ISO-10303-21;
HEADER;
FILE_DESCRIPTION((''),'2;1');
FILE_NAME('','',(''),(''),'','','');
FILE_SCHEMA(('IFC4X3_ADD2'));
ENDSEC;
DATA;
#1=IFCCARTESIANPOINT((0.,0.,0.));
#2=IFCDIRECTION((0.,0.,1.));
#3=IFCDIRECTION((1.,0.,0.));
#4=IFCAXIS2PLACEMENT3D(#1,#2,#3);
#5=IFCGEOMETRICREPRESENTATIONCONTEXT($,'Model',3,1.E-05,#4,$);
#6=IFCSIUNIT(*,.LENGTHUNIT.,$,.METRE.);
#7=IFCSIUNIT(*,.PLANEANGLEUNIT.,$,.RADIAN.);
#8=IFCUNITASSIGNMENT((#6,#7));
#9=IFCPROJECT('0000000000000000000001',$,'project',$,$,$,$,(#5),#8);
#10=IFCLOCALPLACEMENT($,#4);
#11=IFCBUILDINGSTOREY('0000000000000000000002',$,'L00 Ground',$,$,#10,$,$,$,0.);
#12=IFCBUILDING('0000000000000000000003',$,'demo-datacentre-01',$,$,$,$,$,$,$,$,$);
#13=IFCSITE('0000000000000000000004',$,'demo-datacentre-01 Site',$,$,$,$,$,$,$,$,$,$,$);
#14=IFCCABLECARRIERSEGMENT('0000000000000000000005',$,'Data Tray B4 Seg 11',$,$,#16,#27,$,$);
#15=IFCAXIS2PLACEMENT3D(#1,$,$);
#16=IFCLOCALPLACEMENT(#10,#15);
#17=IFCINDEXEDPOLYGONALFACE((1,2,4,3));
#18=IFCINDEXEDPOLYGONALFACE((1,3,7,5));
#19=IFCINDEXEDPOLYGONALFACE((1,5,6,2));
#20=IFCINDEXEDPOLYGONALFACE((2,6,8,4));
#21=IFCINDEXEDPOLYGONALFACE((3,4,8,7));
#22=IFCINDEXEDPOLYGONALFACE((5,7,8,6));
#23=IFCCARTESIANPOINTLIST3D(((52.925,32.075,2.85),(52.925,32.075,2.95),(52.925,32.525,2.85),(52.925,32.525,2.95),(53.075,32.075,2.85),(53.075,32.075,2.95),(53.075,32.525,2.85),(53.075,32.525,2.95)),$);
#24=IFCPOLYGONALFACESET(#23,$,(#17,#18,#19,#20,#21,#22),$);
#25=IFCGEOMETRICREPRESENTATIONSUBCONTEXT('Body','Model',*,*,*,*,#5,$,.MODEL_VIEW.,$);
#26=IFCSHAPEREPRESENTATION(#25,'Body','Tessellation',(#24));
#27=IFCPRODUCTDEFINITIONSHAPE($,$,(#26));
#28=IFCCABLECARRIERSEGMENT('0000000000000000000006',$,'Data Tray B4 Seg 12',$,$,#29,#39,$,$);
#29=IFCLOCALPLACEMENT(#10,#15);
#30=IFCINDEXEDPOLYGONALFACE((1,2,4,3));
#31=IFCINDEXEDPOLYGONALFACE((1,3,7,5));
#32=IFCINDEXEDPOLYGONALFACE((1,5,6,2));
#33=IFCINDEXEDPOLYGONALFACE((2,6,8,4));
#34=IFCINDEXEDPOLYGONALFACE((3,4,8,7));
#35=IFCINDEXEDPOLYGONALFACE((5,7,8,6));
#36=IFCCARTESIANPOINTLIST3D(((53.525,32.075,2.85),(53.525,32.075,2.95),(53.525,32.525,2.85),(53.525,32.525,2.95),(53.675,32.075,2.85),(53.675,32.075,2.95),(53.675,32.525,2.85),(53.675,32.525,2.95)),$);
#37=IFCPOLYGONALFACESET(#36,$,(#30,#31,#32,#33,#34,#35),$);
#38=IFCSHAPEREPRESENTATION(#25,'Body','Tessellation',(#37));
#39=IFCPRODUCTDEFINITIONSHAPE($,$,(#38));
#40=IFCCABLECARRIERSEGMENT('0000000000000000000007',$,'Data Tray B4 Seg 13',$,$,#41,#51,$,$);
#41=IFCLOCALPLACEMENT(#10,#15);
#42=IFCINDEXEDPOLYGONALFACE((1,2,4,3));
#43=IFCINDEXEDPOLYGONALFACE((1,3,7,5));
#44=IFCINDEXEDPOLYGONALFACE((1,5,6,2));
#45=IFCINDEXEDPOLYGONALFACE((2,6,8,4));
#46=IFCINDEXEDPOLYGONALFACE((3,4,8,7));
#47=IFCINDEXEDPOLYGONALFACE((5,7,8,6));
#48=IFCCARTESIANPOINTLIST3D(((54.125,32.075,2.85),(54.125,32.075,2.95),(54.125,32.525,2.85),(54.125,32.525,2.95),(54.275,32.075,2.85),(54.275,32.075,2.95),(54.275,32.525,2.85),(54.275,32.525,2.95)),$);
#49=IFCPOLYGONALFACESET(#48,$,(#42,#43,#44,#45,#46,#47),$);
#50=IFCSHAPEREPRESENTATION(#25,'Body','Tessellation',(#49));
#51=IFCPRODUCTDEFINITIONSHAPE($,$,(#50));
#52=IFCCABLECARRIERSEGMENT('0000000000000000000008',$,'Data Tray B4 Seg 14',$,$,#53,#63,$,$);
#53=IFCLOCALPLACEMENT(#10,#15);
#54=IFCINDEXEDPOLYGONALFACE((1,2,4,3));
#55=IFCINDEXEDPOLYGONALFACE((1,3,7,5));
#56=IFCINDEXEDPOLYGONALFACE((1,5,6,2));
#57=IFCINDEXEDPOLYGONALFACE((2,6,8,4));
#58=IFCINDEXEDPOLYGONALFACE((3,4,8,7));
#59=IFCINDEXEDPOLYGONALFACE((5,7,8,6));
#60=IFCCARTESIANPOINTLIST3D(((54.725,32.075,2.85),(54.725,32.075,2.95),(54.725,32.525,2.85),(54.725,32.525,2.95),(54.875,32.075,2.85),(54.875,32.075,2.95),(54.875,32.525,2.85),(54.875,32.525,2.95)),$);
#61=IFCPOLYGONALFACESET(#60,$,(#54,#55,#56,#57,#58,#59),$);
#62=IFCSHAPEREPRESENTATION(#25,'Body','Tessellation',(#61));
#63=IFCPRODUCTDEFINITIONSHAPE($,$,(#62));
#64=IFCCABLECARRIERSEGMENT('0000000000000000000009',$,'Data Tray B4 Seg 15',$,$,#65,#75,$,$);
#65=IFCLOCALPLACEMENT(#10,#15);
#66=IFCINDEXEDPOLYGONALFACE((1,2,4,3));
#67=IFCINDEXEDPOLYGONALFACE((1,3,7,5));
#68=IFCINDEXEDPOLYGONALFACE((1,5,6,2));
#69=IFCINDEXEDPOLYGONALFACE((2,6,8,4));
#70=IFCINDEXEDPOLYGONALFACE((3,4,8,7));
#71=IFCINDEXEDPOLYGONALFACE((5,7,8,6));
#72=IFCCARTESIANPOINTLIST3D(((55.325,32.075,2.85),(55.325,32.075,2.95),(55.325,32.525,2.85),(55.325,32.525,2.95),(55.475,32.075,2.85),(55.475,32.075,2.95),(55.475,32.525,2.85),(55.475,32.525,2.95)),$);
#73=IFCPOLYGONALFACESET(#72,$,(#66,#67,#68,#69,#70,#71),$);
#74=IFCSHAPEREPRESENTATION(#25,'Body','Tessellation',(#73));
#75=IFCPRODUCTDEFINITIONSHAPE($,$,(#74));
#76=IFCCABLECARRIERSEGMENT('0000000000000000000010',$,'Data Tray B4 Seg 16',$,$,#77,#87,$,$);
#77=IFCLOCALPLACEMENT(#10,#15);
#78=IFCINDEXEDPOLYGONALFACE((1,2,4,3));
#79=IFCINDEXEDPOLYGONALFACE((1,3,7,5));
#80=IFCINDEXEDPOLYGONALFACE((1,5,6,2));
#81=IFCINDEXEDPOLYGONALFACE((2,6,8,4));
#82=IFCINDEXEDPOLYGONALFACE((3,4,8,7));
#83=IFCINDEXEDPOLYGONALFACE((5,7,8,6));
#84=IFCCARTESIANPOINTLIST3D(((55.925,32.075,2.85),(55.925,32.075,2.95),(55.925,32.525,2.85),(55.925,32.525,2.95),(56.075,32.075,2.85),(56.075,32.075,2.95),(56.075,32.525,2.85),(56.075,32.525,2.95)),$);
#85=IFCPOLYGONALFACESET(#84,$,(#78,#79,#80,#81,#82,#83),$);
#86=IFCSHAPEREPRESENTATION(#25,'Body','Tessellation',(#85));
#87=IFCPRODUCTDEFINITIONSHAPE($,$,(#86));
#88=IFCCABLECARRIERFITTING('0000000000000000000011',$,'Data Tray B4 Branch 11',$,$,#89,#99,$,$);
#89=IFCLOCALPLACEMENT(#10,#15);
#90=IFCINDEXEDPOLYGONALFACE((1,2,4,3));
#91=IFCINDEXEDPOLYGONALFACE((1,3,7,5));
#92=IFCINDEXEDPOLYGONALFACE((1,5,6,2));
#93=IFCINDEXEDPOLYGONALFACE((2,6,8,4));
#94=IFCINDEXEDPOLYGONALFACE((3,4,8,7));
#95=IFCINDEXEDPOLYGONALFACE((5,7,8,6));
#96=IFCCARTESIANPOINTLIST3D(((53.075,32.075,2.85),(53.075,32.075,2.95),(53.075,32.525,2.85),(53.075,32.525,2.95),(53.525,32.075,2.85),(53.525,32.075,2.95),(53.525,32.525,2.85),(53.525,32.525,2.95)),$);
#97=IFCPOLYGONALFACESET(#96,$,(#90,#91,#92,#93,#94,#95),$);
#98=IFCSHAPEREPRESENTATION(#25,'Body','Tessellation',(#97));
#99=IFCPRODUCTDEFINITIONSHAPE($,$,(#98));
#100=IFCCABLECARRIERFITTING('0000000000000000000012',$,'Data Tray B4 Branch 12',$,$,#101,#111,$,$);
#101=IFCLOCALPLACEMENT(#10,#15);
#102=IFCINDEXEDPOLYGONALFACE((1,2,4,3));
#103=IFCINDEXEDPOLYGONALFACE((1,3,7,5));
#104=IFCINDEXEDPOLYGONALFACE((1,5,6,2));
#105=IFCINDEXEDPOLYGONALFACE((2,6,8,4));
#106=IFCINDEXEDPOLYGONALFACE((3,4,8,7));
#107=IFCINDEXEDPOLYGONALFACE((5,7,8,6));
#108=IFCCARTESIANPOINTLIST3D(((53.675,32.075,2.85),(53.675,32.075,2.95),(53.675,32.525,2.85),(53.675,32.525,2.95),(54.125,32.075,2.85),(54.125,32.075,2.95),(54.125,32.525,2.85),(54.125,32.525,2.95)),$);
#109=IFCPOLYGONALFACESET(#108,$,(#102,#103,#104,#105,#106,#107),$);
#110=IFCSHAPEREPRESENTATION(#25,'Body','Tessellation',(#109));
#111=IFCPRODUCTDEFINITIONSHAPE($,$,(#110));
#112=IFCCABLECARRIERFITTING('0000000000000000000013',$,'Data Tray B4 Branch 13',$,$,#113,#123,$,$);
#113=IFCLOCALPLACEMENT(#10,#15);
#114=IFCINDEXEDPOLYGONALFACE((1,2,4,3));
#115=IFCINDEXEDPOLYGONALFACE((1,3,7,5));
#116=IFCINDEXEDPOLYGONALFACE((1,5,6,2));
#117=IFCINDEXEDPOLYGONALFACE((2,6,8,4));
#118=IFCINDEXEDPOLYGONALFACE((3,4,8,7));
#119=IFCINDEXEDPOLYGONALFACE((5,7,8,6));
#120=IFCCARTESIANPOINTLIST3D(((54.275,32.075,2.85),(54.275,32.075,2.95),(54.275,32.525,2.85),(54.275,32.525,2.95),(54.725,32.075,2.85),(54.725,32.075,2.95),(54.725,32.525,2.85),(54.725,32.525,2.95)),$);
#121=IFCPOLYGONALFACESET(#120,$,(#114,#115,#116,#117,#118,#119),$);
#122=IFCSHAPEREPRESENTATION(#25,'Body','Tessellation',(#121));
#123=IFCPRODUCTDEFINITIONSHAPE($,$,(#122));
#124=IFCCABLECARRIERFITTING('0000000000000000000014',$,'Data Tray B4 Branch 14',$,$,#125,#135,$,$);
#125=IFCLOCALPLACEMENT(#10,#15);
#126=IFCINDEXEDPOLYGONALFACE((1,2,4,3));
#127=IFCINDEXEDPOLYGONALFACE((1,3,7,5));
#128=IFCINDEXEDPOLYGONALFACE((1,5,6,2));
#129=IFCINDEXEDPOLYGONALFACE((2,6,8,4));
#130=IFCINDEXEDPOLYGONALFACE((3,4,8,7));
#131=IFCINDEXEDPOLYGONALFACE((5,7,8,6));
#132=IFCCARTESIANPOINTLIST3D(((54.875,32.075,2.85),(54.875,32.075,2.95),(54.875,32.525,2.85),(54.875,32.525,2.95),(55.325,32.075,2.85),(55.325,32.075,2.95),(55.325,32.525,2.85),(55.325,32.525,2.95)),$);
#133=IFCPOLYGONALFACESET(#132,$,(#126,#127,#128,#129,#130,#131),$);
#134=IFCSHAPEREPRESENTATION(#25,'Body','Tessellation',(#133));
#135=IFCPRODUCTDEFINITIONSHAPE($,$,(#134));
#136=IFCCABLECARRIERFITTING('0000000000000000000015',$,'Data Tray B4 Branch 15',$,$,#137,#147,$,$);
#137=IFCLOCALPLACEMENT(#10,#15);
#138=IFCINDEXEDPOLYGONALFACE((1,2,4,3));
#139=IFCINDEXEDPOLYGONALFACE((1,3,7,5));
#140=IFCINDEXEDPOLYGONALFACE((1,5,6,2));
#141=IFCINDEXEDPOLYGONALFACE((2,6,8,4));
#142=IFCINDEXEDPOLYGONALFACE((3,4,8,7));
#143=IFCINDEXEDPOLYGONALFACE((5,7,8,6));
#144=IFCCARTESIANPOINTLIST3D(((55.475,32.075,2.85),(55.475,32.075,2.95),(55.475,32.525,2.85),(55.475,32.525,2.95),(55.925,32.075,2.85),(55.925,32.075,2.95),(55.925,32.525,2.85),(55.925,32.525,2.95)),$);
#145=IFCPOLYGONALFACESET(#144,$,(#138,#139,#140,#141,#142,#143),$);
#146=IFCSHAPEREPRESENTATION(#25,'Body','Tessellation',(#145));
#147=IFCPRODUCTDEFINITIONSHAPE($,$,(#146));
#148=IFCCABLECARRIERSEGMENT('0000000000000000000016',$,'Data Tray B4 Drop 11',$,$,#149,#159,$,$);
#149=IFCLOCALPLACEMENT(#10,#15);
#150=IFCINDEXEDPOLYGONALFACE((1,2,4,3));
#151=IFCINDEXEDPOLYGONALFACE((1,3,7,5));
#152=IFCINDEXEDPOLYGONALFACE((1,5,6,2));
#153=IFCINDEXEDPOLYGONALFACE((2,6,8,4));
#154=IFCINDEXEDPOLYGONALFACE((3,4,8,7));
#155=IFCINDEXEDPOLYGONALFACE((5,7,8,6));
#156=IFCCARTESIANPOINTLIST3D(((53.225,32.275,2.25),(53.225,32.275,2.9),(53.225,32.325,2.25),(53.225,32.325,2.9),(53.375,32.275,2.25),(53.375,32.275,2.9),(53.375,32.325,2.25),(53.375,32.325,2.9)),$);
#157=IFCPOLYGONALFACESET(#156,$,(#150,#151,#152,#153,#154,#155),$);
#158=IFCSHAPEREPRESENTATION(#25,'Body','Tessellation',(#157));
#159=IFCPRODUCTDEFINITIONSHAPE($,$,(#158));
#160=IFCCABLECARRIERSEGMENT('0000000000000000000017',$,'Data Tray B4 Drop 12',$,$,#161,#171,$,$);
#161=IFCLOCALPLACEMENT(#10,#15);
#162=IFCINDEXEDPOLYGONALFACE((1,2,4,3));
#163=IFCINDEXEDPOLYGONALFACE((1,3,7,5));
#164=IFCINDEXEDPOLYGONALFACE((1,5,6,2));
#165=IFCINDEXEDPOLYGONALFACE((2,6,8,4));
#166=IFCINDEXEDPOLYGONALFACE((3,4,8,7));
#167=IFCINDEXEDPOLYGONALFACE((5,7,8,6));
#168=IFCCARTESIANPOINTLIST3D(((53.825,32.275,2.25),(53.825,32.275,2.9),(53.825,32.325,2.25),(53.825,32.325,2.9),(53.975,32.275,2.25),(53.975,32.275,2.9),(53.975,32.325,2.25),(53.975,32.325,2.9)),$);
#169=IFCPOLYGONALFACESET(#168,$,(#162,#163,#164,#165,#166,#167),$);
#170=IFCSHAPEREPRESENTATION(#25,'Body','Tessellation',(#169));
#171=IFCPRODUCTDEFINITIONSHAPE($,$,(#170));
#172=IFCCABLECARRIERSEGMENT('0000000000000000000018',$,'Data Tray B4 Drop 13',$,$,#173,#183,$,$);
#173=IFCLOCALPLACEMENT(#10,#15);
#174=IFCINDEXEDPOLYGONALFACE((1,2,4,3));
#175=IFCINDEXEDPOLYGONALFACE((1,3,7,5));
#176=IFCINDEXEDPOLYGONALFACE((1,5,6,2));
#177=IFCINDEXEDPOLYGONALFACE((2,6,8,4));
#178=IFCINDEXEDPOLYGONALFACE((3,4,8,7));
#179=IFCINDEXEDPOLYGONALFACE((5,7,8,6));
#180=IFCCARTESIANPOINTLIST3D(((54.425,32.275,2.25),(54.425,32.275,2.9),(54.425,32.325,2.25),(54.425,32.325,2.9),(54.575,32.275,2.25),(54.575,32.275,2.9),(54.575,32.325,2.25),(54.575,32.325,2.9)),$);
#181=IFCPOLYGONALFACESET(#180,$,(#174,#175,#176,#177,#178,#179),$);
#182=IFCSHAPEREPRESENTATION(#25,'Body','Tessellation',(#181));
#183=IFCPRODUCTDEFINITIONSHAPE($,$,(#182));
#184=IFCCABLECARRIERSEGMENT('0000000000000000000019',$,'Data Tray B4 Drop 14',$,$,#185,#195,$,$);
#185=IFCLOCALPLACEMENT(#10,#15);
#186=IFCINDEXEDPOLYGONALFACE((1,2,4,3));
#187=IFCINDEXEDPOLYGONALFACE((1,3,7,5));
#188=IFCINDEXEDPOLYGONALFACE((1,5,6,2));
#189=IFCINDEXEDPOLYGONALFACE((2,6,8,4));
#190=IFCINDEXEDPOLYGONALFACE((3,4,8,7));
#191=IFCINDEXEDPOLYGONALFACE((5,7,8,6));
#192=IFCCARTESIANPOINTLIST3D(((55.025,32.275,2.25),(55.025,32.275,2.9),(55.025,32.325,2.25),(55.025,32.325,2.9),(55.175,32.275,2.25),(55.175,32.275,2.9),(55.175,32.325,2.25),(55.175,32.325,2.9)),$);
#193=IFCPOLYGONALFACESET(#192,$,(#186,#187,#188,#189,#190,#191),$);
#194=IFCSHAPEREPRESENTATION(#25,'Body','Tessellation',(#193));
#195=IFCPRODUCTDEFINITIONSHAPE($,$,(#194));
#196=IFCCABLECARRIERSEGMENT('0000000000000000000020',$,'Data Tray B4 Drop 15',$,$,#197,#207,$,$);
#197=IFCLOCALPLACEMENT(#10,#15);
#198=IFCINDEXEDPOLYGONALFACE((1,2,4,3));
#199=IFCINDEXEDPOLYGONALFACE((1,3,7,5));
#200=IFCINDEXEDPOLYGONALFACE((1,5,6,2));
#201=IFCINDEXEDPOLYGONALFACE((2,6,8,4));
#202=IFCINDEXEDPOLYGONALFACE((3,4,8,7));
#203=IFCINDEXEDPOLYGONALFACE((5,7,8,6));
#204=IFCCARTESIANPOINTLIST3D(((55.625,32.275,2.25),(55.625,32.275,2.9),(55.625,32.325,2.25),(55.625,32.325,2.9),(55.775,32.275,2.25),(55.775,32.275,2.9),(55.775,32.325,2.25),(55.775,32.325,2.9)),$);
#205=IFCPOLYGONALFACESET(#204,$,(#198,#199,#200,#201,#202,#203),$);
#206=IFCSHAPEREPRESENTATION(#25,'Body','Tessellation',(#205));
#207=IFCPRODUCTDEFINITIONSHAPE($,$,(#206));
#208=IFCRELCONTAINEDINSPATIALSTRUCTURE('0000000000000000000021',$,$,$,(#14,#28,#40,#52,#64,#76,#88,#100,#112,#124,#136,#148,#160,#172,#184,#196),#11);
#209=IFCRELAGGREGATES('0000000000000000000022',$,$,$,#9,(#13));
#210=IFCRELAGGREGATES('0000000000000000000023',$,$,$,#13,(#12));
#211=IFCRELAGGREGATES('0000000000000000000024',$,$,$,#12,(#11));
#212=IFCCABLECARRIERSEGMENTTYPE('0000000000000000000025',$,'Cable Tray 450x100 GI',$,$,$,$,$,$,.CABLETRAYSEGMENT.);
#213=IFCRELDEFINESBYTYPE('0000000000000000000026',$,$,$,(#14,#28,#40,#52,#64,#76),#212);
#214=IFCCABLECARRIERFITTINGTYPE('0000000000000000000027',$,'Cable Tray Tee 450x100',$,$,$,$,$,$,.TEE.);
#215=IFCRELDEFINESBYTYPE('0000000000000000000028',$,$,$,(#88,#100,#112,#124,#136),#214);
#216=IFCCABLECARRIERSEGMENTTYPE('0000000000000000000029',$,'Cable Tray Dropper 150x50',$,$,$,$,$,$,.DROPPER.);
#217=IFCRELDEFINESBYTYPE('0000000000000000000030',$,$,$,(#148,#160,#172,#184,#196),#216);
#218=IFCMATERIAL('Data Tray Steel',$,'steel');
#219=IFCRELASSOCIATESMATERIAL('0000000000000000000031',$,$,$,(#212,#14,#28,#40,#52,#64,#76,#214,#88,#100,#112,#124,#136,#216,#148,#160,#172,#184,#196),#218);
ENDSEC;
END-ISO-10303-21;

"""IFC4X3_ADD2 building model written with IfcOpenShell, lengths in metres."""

from ifc_helpers import new_model, si_unit, frame, origin_with_axes, place, context, subcontext, project, spatial, rectangle, extrude, material, type_object, element, save


model = new_model("IFC4X3_ADD2")

# Units and contexts
model_context = context("Model", 3, precision=1e-05, world=origin_with_axes())
body_context = subcontext(model_context, "Body", "Model", "MODEL_VIEW")
ifc_project = project(units=[si_unit("LENGTHUNIT", "METRE"), si_unit("PLANEANGLEUNIT", "RADIAN")], contexts=[model_context])

# Site, building, storey
site = spatial("IfcSite", under=ifc_project, Name="demo-datacentre-01 Site")
building = spatial("IfcBuilding", under=site, Name="demo-datacentre-01")
storey_placement = place(None, origin_with_axes())
storey = spatial("IfcBuildingStorey", under=building, at=storey_placement, Name="L00 Ground", Elevation=0.0)

# Cable carrier segments
ifc_material_1 = material(Name="Data Tray Steel", Category="steel")
cable_carrier_segment_type_1 = type_object("IfcCableCarrierSegmentType", Name="Cable Tray 450x100 GI", PredefinedType="CABLETRAYSEGMENT", material=ifc_material_1)
for number, where, z_axis, x_axis, name in (
    (1, (52.925, 32.3, 2.9), (1.0, 0.0, 0.0), (0.0, 1.0, 0.0), "Data Tray B4 Seg 11"),
    (2, (53.525, 32.3, 2.9), (1.0, 0.0, 0.0), (0.0, 1.0, 0.0), "Data Tray B4 Seg 12"),
    (3, (54.125, 32.3, 2.9), (1.0, 0.0, 0.0), (0.0, 1.0, 0.0), "Data Tray B4 Seg 13"),
):
    element("IfcCableCarrierSegment", number, at=place(storey_placement, frame(where, z_axis=z_axis, x_axis=x_axis)), inside=storey, type_object=cable_carrier_segment_type_1, material=ifc_material_1, Name=name, context=body_context, shape_type="SweptSolid", body=[
        extrude(rectangle(XDim=0.45, YDim=0.1), origin_with_axes(), (0.0, 0.0, 1.0), 0.15),
    ])
cable_carrier_segment_placement = place(storey_placement, frame((54.725, 32.3, 2.9), z_axis=(1.0, 0.0, 0.0), x_axis=(0.0, 1.0, 0.0)))
element("IfcCableCarrierSegment", 4, at=cable_carrier_segment_placement, inside=storey, type_object=cable_carrier_segment_type_1, material=ifc_material_1, Name="Data Tray B4 Seg 14", context=body_context, shape_type="SweptSolid", body=[
    extrude(rectangle(XDim=0.45, YDim=0.1), origin_with_axes(), (0.0, 0.0, 1.0), 0.15),
])
for number, where, z_axis, x_axis, name in (
    (5, (55.325, 32.3, 2.9), (1.0, 0.0, 0.0), (0.0, 1.0, 0.0), "Data Tray B4 Seg 15"),
    (6, (55.925, 32.3, 2.9), (1.0, 0.0, 0.0), (0.0, 1.0, 0.0), "Data Tray B4 Seg 16"),
):
    element("IfcCableCarrierSegment", number, at=place(storey_placement, frame(where, z_axis=z_axis, x_axis=x_axis)), inside=storey, type_object=cable_carrier_segment_type_1, material=ifc_material_1, Name=name, context=body_context, shape_type="SweptSolid", body=[
        extrude(rectangle(XDim=0.45, YDim=0.1), origin_with_axes(), (0.0, 0.0, 1.0), 0.15),
    ])

# Cable carrier fittings
cable_carrier_fitting_type = type_object("IfcCableCarrierFittingType", Name="Cable Tray Tee 450x100", PredefinedType="TEE", material=ifc_material_1)
for number, where, z_axis, x_axis, name in (
    (7, (53.3, 32.3, 2.85), (0.0, 0.0, 1.0), (1.0, 0.0, 0.0), "Data Tray B4 Branch 11"),
    (8, (53.9, 32.3, 2.85), (0.0, 0.0, 1.0), (1.0, 0.0, 0.0), "Data Tray B4 Branch 12"),
    (9, (54.5, 32.3, 2.85), (0.0, 0.0, 1.0), (1.0, 0.0, 0.0), "Data Tray B4 Branch 13"),
    (10, (55.1, 32.3, 2.85), (0.0, 0.0, 1.0), (1.0, 0.0, 0.0), "Data Tray B4 Branch 14"),
    (11, (55.7, 32.3, 2.85), (0.0, 0.0, 1.0), (1.0, 0.0, 0.0), "Data Tray B4 Branch 15"),
):
    element("IfcCableCarrierFitting", number, at=place(storey_placement, frame(where, z_axis=z_axis, x_axis=x_axis)), inside=storey, type_object=cable_carrier_fitting_type, material=ifc_material_1, Name=name, context=body_context, shape_type="SweptSolid", body=[
        extrude(rectangle(XDim=0.45, YDim=0.45), origin_with_axes(), (0.0, 0.0, 1.0), 0.1),
    ])

# Cable carrier segments
cable_carrier_segment_type_2 = type_object("IfcCableCarrierSegmentType", Name="Cable Tray Dropper 150x50", PredefinedType="DROPPER", material=ifc_material_1)
for number, where, z_axis, x_axis, name in (
    (12, (53.3, 32.3, 2.9), (0.0, 0.0, -1.0), (1.0, 0.0, 0.0), "Data Tray B4 Drop 11"),
    (13, (53.9, 32.3, 2.9), (0.0, 0.0, -1.0), (1.0, 0.0, 0.0), "Data Tray B4 Drop 12"),
    (14, (54.5, 32.3, 2.9), (0.0, 0.0, -1.0), (1.0, 0.0, 0.0), "Data Tray B4 Drop 13"),
    (15, (55.1, 32.3, 2.9), (0.0, 0.0, -1.0), (1.0, 0.0, 0.0), "Data Tray B4 Drop 14"),
    (16, (55.7, 32.3, 2.9), (0.0, 0.0, -1.0), (1.0, 0.0, 0.0), "Data Tray B4 Drop 15"),
):
    element("IfcCableCarrierSegment", number, at=place(storey_placement, frame(where, z_axis=z_axis, x_axis=x_axis)), inside=storey, type_object=cable_carrier_segment_type_2, material=ifc_material_1, Name=name, context=body_context, shape_type="SweptSolid", body=[
        extrude(rectangle(XDim=0.15, YDim=0.05), origin_with_axes(), (0.0, 0.0, 1.0), 0.65),
    ])

save(model, "model.ifc")
